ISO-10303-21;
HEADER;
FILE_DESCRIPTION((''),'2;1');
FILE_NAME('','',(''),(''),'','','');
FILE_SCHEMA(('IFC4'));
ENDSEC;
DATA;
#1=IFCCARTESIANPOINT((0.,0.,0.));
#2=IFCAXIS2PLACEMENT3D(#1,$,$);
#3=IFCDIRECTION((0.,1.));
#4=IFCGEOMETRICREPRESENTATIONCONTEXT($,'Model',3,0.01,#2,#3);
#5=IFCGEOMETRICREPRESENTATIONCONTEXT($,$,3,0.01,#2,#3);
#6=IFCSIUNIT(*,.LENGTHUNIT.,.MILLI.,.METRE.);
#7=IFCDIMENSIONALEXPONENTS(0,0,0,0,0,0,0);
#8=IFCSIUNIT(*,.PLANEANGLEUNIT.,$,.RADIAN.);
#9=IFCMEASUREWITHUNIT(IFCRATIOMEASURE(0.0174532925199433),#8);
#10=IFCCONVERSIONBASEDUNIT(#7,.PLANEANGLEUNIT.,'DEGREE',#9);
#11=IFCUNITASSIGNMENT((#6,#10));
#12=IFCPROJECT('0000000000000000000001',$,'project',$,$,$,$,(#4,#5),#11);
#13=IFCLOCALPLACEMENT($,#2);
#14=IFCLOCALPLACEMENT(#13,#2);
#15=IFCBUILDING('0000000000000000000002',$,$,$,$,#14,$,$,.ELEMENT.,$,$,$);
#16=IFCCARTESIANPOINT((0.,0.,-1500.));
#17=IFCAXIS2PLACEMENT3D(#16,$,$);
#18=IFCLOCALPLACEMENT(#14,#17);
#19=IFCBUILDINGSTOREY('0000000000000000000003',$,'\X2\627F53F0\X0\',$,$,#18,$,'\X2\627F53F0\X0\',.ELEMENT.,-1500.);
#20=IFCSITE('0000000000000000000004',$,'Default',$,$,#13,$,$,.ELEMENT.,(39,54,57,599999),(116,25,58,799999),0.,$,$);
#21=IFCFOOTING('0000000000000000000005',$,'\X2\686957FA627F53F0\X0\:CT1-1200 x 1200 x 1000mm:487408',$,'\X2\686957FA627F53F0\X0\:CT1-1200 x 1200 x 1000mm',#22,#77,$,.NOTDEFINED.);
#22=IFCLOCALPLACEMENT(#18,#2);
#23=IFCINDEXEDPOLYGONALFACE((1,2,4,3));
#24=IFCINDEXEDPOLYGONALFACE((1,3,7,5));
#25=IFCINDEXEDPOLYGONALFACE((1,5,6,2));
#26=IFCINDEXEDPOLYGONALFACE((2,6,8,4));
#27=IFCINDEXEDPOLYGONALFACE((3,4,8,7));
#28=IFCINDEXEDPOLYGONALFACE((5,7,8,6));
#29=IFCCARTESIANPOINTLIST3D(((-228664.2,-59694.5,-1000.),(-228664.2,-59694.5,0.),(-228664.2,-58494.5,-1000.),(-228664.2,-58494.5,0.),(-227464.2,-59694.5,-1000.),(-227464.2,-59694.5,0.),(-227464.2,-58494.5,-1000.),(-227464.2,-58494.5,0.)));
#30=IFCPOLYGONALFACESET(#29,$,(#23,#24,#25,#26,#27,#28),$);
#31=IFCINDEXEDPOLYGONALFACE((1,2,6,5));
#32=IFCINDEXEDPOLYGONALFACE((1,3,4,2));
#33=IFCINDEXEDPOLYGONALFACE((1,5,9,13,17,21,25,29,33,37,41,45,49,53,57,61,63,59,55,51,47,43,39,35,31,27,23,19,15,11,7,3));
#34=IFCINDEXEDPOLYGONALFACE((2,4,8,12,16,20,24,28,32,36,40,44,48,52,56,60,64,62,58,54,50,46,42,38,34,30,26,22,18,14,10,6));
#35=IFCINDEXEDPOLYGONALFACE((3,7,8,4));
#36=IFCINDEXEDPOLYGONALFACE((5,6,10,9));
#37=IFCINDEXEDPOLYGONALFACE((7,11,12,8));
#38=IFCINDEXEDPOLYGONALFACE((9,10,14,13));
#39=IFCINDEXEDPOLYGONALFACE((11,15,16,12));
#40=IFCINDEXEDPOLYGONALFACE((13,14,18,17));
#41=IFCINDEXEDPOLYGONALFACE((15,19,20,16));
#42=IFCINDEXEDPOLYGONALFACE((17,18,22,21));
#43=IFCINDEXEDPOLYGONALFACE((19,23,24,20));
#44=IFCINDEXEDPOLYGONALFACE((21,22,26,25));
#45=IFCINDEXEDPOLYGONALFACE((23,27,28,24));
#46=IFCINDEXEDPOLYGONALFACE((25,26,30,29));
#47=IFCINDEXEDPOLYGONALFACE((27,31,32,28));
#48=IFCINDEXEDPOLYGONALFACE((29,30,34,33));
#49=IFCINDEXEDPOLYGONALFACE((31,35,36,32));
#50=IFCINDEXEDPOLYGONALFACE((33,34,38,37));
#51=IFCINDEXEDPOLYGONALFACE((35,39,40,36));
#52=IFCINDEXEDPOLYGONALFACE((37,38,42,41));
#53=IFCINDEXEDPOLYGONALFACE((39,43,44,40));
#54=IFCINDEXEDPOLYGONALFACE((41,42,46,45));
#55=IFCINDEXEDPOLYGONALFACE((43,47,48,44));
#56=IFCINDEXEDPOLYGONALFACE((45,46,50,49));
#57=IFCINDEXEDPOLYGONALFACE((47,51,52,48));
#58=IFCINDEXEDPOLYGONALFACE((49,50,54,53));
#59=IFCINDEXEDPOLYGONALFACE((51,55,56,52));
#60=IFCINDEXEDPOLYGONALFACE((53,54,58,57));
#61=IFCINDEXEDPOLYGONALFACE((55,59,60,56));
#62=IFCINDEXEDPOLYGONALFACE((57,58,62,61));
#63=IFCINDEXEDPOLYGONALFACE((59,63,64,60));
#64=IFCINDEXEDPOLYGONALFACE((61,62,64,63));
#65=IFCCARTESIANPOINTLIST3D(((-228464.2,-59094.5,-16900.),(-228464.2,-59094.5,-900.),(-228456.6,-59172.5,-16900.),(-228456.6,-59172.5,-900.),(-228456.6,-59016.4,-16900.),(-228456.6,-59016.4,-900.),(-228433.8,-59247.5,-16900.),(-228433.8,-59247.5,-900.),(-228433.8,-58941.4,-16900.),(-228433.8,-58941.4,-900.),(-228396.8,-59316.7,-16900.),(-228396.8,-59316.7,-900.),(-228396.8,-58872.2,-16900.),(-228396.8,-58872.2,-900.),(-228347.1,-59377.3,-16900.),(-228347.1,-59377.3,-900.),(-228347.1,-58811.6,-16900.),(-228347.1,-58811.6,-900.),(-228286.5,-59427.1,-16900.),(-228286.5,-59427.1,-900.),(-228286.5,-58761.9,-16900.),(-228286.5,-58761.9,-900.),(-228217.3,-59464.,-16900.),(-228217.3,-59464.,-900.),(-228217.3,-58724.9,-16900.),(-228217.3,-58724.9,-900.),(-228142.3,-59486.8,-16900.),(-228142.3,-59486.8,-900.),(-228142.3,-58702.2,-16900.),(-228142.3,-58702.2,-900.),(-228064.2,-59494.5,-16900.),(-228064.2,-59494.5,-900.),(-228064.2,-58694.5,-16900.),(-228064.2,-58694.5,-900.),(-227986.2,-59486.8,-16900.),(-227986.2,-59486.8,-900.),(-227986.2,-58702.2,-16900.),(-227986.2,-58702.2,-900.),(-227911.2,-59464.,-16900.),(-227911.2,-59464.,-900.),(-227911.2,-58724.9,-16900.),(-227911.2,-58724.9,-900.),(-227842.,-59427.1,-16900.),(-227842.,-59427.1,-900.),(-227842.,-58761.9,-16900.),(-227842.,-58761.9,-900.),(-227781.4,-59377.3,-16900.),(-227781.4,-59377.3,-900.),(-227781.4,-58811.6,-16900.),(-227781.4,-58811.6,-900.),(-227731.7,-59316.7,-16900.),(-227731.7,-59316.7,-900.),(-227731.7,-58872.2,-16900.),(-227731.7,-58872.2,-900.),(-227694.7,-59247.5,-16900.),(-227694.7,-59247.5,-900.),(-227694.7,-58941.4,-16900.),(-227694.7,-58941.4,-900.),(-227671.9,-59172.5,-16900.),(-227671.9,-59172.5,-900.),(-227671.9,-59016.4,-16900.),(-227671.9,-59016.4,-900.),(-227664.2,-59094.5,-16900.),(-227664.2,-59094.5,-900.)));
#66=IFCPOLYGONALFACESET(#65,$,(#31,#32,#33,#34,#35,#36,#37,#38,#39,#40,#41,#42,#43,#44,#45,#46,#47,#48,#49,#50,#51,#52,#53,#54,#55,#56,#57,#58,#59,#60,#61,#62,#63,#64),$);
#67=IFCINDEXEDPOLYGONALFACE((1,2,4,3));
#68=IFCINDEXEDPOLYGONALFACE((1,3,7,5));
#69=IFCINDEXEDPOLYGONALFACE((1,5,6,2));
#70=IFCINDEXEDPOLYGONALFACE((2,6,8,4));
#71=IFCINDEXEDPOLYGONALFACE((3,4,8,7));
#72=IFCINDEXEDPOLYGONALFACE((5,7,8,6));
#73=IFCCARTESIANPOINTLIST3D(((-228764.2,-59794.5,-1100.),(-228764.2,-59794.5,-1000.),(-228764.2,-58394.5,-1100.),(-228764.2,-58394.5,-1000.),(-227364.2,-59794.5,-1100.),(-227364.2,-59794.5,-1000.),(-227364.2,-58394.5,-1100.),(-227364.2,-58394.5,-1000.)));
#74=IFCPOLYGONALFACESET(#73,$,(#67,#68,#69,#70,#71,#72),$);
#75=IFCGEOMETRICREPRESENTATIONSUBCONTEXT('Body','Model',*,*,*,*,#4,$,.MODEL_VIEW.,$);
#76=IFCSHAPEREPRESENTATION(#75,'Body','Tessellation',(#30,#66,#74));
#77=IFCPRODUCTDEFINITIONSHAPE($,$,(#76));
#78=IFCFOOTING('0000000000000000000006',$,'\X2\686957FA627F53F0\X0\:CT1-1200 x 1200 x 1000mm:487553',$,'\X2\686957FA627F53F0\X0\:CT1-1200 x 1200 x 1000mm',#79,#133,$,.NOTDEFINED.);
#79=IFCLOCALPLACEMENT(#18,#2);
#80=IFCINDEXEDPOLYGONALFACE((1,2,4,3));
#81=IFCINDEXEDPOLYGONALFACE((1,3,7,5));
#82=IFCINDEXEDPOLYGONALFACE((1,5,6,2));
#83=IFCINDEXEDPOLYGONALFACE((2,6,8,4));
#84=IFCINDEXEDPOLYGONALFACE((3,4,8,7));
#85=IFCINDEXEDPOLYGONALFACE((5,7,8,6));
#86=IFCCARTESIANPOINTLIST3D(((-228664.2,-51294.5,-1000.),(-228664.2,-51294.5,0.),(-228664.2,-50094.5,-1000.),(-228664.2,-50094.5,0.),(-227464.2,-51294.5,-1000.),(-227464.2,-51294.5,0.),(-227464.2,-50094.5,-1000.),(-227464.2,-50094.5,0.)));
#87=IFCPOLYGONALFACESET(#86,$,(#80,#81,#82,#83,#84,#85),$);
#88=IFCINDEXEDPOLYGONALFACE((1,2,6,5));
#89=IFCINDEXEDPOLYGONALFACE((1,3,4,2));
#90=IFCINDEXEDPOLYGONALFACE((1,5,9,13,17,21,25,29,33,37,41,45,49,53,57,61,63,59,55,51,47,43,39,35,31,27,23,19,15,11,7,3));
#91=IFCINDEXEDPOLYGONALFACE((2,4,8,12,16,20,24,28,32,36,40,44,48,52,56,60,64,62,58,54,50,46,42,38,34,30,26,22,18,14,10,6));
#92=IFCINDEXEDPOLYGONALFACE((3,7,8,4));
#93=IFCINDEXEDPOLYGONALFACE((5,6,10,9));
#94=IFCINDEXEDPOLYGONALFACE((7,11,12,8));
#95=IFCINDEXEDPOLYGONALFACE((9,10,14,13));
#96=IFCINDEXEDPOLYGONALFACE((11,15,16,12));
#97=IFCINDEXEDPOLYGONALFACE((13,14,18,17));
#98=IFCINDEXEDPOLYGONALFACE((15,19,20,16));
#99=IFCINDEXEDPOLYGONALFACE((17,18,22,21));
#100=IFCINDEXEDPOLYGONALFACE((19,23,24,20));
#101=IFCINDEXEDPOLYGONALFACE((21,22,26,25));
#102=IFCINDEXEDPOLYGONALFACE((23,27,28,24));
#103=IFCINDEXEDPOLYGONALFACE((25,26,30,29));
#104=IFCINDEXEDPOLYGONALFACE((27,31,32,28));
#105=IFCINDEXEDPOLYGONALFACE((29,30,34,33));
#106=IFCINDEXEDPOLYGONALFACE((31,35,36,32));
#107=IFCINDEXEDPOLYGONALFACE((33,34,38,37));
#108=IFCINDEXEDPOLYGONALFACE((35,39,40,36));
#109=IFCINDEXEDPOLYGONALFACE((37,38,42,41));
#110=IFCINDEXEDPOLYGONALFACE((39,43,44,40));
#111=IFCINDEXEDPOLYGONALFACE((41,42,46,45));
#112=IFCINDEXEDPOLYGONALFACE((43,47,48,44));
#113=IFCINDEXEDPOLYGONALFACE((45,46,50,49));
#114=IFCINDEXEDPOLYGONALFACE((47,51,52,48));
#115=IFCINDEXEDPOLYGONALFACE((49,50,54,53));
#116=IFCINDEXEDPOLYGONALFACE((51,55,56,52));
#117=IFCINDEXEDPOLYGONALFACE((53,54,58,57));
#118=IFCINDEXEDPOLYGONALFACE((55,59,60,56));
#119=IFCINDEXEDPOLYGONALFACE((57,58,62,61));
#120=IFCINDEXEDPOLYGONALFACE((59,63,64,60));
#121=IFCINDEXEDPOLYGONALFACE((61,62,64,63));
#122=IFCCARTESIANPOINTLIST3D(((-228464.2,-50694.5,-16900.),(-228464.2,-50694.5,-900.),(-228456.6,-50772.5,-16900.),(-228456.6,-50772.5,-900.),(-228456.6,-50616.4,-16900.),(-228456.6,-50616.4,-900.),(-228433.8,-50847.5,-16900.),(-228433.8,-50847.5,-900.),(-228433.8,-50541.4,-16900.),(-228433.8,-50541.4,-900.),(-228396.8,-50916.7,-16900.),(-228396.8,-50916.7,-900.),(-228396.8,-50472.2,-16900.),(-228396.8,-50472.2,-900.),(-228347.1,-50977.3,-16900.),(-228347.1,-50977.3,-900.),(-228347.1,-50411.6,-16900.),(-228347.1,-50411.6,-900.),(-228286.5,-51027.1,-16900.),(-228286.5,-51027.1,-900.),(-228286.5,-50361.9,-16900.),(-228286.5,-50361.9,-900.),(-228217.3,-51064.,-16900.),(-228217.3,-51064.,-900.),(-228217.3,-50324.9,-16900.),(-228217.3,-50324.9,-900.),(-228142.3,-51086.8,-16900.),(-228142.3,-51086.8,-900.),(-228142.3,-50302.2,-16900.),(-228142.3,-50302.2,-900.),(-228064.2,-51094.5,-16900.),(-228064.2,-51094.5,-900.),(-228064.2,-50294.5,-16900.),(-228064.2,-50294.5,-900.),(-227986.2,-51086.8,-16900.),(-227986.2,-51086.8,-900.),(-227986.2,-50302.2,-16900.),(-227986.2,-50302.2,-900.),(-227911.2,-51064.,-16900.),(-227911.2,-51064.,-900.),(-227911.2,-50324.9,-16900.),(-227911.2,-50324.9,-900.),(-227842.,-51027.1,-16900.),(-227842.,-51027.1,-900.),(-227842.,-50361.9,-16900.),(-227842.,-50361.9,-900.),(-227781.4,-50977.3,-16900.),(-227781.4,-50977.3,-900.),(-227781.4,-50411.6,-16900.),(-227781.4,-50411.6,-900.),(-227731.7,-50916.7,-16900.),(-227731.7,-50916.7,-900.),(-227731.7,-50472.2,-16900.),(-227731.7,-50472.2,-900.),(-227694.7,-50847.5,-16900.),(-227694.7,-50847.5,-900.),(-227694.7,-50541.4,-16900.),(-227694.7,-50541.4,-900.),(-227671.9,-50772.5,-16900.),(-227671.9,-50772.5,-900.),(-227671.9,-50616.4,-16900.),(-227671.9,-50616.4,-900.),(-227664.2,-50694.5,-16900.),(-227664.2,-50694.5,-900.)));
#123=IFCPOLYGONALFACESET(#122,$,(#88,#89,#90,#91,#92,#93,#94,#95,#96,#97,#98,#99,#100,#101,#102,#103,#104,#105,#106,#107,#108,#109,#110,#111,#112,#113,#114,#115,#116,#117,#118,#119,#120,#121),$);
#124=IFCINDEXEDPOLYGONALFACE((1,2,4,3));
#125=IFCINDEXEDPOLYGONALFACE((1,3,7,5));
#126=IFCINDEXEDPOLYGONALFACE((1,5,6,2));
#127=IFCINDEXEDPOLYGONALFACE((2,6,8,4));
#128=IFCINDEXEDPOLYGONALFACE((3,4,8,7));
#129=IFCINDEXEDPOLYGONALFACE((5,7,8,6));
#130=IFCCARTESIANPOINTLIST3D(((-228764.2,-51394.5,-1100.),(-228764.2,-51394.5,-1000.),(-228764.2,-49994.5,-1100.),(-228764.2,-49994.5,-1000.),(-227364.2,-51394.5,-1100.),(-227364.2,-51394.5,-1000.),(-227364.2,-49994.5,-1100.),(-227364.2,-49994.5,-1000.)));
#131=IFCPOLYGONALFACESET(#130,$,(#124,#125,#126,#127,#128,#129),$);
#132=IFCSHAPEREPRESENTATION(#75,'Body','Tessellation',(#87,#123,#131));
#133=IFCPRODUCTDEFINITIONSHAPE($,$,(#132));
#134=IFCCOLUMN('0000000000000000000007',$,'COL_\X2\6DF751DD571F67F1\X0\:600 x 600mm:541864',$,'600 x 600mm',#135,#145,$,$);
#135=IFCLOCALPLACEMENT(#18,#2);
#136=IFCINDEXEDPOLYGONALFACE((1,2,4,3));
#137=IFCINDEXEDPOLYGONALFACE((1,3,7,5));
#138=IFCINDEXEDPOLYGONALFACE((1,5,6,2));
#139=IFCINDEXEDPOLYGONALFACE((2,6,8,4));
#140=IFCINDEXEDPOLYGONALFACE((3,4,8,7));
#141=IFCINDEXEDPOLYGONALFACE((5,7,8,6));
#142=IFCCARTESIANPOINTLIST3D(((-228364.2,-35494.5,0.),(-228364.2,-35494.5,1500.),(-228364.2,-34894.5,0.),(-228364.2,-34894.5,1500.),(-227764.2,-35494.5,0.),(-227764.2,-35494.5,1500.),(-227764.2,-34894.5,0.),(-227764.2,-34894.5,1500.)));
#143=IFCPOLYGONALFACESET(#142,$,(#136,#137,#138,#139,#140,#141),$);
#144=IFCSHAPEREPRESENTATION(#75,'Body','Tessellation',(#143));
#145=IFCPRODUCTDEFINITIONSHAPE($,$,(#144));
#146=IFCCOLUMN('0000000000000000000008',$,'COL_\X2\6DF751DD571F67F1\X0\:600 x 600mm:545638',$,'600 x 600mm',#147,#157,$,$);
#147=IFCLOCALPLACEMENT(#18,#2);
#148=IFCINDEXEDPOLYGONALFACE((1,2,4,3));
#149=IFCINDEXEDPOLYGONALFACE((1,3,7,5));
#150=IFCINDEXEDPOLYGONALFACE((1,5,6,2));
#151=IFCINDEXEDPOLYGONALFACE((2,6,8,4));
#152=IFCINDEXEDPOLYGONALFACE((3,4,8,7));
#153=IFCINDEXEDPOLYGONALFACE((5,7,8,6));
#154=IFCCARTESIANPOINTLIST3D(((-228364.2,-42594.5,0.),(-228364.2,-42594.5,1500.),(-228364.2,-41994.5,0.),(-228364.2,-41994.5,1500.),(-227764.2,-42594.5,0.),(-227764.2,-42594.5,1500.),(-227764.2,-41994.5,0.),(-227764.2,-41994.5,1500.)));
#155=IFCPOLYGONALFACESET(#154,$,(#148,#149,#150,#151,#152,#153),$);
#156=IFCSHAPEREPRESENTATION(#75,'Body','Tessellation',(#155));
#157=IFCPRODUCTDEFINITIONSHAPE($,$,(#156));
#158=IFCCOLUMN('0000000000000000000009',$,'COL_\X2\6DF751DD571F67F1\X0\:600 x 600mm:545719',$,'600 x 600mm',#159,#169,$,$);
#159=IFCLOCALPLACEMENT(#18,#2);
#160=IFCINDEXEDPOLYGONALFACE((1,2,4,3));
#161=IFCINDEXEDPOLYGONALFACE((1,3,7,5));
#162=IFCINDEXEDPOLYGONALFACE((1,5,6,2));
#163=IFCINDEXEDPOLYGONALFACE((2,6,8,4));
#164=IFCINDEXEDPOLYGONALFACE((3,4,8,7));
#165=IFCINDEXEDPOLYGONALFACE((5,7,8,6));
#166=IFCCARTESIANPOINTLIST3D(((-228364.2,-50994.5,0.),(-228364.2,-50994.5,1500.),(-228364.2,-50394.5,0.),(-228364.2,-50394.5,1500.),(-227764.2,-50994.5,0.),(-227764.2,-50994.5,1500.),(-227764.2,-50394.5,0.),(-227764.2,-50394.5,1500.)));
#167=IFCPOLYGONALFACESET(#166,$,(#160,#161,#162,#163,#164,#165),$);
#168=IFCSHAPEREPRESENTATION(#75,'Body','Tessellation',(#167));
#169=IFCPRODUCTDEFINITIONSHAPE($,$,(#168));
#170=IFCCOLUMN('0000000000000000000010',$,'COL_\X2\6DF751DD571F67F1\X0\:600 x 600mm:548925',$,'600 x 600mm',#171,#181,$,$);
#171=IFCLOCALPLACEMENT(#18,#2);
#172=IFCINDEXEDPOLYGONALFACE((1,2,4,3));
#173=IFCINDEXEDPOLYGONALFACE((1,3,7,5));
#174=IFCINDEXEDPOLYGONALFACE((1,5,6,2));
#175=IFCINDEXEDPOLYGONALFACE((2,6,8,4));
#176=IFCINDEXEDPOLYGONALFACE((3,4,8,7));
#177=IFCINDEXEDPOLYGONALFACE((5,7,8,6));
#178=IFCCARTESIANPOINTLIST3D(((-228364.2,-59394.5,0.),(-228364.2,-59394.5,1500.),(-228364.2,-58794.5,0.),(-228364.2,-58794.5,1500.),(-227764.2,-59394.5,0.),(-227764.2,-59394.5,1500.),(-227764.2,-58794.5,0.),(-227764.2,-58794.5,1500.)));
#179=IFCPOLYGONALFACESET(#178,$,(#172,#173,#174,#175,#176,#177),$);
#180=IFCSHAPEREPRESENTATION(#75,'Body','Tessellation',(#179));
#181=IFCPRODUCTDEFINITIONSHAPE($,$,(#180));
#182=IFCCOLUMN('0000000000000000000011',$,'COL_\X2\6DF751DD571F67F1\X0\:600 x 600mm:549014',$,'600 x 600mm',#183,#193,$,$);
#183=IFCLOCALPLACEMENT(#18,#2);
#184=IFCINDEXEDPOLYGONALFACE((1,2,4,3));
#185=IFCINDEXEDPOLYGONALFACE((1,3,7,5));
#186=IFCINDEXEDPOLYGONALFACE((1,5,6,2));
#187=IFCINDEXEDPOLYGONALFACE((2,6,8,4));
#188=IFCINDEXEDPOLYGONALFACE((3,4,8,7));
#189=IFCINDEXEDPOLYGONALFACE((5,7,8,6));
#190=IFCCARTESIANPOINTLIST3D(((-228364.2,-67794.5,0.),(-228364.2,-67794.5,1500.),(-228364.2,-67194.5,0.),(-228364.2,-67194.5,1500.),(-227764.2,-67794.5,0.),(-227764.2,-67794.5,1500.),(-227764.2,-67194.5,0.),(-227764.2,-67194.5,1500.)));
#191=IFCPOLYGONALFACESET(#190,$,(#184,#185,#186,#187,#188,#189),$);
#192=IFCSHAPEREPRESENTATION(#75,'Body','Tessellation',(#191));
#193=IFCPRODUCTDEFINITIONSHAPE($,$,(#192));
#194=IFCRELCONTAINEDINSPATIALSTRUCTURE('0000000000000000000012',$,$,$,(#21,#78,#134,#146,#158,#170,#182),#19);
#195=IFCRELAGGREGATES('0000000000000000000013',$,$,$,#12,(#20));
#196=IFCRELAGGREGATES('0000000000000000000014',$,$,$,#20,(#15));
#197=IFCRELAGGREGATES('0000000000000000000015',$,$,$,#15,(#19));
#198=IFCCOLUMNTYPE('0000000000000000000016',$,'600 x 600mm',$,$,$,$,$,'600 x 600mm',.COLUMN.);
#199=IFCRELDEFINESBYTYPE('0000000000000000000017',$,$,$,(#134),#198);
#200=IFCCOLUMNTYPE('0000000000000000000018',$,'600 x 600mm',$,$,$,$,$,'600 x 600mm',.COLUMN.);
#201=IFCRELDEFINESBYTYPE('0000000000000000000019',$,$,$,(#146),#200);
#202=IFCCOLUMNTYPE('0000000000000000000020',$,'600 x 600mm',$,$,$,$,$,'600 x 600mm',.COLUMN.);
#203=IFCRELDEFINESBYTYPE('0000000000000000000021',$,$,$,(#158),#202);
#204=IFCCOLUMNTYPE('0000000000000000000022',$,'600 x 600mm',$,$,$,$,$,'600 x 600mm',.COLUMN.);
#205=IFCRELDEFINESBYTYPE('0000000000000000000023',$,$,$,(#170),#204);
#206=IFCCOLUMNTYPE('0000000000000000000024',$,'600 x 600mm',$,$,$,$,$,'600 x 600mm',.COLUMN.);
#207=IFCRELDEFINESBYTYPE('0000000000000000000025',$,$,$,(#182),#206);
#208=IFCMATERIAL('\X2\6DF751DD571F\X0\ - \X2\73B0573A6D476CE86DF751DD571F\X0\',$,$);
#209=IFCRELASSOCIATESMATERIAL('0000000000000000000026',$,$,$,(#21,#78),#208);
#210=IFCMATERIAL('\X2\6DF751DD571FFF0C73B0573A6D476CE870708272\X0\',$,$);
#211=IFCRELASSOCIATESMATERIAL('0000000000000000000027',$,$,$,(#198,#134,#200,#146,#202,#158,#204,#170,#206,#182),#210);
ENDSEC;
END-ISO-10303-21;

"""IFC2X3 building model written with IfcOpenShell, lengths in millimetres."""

from ifc_helpers import new_model, entity, si_unit, converted_unit, direction, frame, frame_2d, origin, origin_2d_with_axis, place, context, subcontext, project, spatial, rectangle, circle, extrude, source, transform, mapped, material, type_object, type_shapes, element, save


model = new_model("IFC2X3")

# Units and contexts
model_context = context("Model", 3, precision=0.01, world=origin(), true_north=direction((0.0, 1.0)))
context_of_model = context(None, 3, precision=0.01, world=origin(), true_north=direction((0.0, 1.0)))
body_context = subcontext(model_context, "Body", "Model", "MODEL_VIEW")
ifc_project = project(units=[si_unit("LENGTHUNIT", "METRE", prefix="MILLI"), converted_unit("PLANEANGLEUNIT", "DEGREE", entity("IfcRatioMeasure", 0.0174532925199433), si_unit("PLANEANGLEUNIT", "RADIAN"), dimensions=[0, 0, 0, 0, 0, 0, 0])], contexts=[model_context, context_of_model])

# Site, building, storey
site_placement = place(None, origin())
site = spatial("IfcSite", under=ifc_project, at=site_placement, Name="Default", CompositionType="ELEMENT", RefLatitude=(39, 54, 57, 599999), RefLongitude=(116, 25, 58, 799999), RefElevation=0.0)
building_placement = place(site_placement, origin())
building = spatial("IfcBuilding", under=site, at=building_placement, CompositionType="ELEMENT")
storey_placement = place(building_placement, frame((0.0, 0.0, -1500.0)))
storey = spatial("IfcBuildingStorey", under=building, at=storey_placement, Name="承台", LongName="承台", CompositionType="ELEMENT", Elevation=-1500.0)

# Footings
ifc_material_1 = material(Name="混凝土 - 现场浇注混凝土")
for number, where, name in (
    (1, (-228764.2, -59794.5, -16900.0), "桩基承台:CT1-1200 x 1200 x 1000mm:487408"),
    (2, (-228764.2, -51394.5, -16900.0), "桩基承台:CT1-1200 x 1200 x 1000mm:487553"),
):
    element("IfcFooting", number, at=place(storey_placement, frame(where)), inside=storey, material=ifc_material_1, Name=name, ObjectType="桩基承台:CT1-1200 x 1200 x 1000mm", PredefinedType="NOTDEFINED", context=body_context, shape_type="SweptSolid", body=[
        extrude(rectangle(XDim=1200.0, YDim=1200.0, at=frame_2d((0.0, 0.0), x_axis=(1.0, 0.0))), frame((700.0, 700.0, 15900.0), z_axis=(0.0, 0.0, 1.0), x_axis=(-1.0, 0.0, 0.0)), (0.0, 0.0, 1.0), 1000.0),
        extrude(circle(Radius=400.0, at=origin_2d_with_axis()), frame((700.0, 700.0, 0.0)), (0.0, 0.0, 1.0), 16000.0),
        extrude(rectangle(XDim=1400.0, YDim=1400.0, at=frame_2d((0.0, 0.0), x_axis=(1.0, 0.0))), frame((700.0, 700.0, 15800.0), z_axis=(0.0, 0.0, 1.0), x_axis=(0.0, 1.0, 0.0)), (0.0, 0.0, 1.0), 100.0),
    ])

# Columns
ifc_material_2 = material(Name="混凝土，现场浇注灰色")
column_type_1 = type_object("IfcColumnType", Name="600 x 600mm", ElementType="600 x 600mm", PredefinedType="COLUMN", material=ifc_material_2)
shared_shape_1 = source(origin(), body_context, "Body", "SweptSolid", [
    extrude(rectangle(XDim=600.0, YDim=600.0, at=frame_2d((0.0, 0.0), x_axis=(1.0, 0.0))), frame((300.0, 300.0, 0.0), z_axis=(0.0, 0.0, 1.0), x_axis=(-1.0, 0.0, 0.0)), (0.0, 0.0, 1.0), 1500.0),
])
type_shapes(column_type_1, [shared_shape_1])
column_1_placement = place(storey_placement, frame((-228364.2, -35494.5, 0.0)))
element("IfcColumn", 3, at=column_1_placement, inside=storey, type_object=column_type_1, material=ifc_material_2, Name="COL_混凝土柱:600 x 600mm:541864", ObjectType="600 x 600mm", context=body_context, shape_type="MappedRepresentation", body=[
    mapped(shared_shape_1, transform((0.0, 0.0, 0.0), scale=1.0)),
])
column_type_2 = type_object("IfcColumnType", Name="600 x 600mm", ElementType="600 x 600mm", PredefinedType="COLUMN", material=ifc_material_2)
shared_shape_2 = source(origin(), body_context, "Body", "SweptSolid", [
    extrude(rectangle(XDim=600.0, YDim=600.0, at=origin_2d_with_axis()), frame((300.0, 300.0, 0.0), z_axis=(0.0, 0.0, 1.0), x_axis=(-1.0, 0.0, 0.0)), (0.0, 0.0, 1.0), 1500.0),
])
type_shapes(column_type_2, [shared_shape_2])
column_2_placement = place(storey_placement, frame((-228364.2, -42594.5, 0.0)))
element("IfcColumn", 4, at=column_2_placement, inside=storey, type_object=column_type_2, material=ifc_material_2, Name="COL_混凝土柱:600 x 600mm:545638", ObjectType="600 x 600mm", context=body_context, shape_type="MappedRepresentation", body=[
    mapped(shared_shape_2, transform((0.0, 0.0, 0.0), scale=1.0)),
])
column_type_3 = type_object("IfcColumnType", Name="600 x 600mm", ElementType="600 x 600mm", PredefinedType="COLUMN", material=ifc_material_2)
shared_shape_3 = source(origin(), body_context, "Body", "SweptSolid", [
    extrude(rectangle(XDim=600.0, YDim=600.0, at=origin_2d_with_axis()), frame((300.0, 300.0, 0.0), z_axis=(0.0, 0.0, 1.0), x_axis=(-1.0, 0.0, 0.0)), (0.0, 0.0, 1.0), 1500.0),
])
type_shapes(column_type_3, [shared_shape_3])
column_3_placement = place(storey_placement, frame((-228364.2, -50994.5, 0.0)))
element("IfcColumn", 5, at=column_3_placement, inside=storey, type_object=column_type_3, material=ifc_material_2, Name="COL_混凝土柱:600 x 600mm:545719", ObjectType="600 x 600mm", context=body_context, shape_type="MappedRepresentation", body=[
    mapped(shared_shape_3, transform((0.0, 0.0, 0.0), scale=1.0)),
])
column_type_4 = type_object("IfcColumnType", Name="600 x 600mm", ElementType="600 x 600mm", PredefinedType="COLUMN", material=ifc_material_2)
shared_shape_4 = source(origin(), body_context, "Body", "SweptSolid", [
    extrude(rectangle(XDim=600.0, YDim=600.0, at=origin_2d_with_axis()), frame((300.0, 300.0, 0.0), z_axis=(0.0, 0.0, 1.0), x_axis=(-1.0, 0.0, 0.0)), (0.0, 0.0, 1.0), 1500.0),
])
type_shapes(column_type_4, [shared_shape_4])
column_4_placement = place(storey_placement, frame((-228364.2, -59394.5, 0.0)))
element("IfcColumn", 6, at=column_4_placement, inside=storey, type_object=column_type_4, material=ifc_material_2, Name="COL_混凝土柱:600 x 600mm:548925", ObjectType="600 x 600mm", context=body_context, shape_type="MappedRepresentation", body=[
    mapped(shared_shape_4, transform((0.0, 0.0, 0.0), scale=1.0)),
])
column_type_5 = type_object("IfcColumnType", Name="600 x 600mm", ElementType="600 x 600mm", PredefinedType="COLUMN", material=ifc_material_2)
shared_shape_5 = source(origin(), body_context, "Body", "SweptSolid", [
    extrude(rectangle(XDim=600.0, YDim=600.0, at=origin_2d_with_axis()), frame((300.0, 300.0, 0.0), z_axis=(0.0, 0.0, 1.0), x_axis=(-1.0, 0.0, 0.0)), (0.0, 0.0, 1.0), 1500.0),
])
type_shapes(column_type_5, [shared_shape_5])
column_5_placement = place(storey_placement, frame((-228364.2, -67794.5, 0.0)))
element("IfcColumn", 7, at=column_5_placement, inside=storey, type_object=column_type_5, material=ifc_material_2, Name="COL_混凝土柱:600 x 600mm:549014", ObjectType="600 x 600mm", context=body_context, shape_type="MappedRepresentation", body=[
    mapped(shared_shape_5, transform((0.0, 0.0, 0.0), scale=1.0)),
])

save(model, "model.ifc")
